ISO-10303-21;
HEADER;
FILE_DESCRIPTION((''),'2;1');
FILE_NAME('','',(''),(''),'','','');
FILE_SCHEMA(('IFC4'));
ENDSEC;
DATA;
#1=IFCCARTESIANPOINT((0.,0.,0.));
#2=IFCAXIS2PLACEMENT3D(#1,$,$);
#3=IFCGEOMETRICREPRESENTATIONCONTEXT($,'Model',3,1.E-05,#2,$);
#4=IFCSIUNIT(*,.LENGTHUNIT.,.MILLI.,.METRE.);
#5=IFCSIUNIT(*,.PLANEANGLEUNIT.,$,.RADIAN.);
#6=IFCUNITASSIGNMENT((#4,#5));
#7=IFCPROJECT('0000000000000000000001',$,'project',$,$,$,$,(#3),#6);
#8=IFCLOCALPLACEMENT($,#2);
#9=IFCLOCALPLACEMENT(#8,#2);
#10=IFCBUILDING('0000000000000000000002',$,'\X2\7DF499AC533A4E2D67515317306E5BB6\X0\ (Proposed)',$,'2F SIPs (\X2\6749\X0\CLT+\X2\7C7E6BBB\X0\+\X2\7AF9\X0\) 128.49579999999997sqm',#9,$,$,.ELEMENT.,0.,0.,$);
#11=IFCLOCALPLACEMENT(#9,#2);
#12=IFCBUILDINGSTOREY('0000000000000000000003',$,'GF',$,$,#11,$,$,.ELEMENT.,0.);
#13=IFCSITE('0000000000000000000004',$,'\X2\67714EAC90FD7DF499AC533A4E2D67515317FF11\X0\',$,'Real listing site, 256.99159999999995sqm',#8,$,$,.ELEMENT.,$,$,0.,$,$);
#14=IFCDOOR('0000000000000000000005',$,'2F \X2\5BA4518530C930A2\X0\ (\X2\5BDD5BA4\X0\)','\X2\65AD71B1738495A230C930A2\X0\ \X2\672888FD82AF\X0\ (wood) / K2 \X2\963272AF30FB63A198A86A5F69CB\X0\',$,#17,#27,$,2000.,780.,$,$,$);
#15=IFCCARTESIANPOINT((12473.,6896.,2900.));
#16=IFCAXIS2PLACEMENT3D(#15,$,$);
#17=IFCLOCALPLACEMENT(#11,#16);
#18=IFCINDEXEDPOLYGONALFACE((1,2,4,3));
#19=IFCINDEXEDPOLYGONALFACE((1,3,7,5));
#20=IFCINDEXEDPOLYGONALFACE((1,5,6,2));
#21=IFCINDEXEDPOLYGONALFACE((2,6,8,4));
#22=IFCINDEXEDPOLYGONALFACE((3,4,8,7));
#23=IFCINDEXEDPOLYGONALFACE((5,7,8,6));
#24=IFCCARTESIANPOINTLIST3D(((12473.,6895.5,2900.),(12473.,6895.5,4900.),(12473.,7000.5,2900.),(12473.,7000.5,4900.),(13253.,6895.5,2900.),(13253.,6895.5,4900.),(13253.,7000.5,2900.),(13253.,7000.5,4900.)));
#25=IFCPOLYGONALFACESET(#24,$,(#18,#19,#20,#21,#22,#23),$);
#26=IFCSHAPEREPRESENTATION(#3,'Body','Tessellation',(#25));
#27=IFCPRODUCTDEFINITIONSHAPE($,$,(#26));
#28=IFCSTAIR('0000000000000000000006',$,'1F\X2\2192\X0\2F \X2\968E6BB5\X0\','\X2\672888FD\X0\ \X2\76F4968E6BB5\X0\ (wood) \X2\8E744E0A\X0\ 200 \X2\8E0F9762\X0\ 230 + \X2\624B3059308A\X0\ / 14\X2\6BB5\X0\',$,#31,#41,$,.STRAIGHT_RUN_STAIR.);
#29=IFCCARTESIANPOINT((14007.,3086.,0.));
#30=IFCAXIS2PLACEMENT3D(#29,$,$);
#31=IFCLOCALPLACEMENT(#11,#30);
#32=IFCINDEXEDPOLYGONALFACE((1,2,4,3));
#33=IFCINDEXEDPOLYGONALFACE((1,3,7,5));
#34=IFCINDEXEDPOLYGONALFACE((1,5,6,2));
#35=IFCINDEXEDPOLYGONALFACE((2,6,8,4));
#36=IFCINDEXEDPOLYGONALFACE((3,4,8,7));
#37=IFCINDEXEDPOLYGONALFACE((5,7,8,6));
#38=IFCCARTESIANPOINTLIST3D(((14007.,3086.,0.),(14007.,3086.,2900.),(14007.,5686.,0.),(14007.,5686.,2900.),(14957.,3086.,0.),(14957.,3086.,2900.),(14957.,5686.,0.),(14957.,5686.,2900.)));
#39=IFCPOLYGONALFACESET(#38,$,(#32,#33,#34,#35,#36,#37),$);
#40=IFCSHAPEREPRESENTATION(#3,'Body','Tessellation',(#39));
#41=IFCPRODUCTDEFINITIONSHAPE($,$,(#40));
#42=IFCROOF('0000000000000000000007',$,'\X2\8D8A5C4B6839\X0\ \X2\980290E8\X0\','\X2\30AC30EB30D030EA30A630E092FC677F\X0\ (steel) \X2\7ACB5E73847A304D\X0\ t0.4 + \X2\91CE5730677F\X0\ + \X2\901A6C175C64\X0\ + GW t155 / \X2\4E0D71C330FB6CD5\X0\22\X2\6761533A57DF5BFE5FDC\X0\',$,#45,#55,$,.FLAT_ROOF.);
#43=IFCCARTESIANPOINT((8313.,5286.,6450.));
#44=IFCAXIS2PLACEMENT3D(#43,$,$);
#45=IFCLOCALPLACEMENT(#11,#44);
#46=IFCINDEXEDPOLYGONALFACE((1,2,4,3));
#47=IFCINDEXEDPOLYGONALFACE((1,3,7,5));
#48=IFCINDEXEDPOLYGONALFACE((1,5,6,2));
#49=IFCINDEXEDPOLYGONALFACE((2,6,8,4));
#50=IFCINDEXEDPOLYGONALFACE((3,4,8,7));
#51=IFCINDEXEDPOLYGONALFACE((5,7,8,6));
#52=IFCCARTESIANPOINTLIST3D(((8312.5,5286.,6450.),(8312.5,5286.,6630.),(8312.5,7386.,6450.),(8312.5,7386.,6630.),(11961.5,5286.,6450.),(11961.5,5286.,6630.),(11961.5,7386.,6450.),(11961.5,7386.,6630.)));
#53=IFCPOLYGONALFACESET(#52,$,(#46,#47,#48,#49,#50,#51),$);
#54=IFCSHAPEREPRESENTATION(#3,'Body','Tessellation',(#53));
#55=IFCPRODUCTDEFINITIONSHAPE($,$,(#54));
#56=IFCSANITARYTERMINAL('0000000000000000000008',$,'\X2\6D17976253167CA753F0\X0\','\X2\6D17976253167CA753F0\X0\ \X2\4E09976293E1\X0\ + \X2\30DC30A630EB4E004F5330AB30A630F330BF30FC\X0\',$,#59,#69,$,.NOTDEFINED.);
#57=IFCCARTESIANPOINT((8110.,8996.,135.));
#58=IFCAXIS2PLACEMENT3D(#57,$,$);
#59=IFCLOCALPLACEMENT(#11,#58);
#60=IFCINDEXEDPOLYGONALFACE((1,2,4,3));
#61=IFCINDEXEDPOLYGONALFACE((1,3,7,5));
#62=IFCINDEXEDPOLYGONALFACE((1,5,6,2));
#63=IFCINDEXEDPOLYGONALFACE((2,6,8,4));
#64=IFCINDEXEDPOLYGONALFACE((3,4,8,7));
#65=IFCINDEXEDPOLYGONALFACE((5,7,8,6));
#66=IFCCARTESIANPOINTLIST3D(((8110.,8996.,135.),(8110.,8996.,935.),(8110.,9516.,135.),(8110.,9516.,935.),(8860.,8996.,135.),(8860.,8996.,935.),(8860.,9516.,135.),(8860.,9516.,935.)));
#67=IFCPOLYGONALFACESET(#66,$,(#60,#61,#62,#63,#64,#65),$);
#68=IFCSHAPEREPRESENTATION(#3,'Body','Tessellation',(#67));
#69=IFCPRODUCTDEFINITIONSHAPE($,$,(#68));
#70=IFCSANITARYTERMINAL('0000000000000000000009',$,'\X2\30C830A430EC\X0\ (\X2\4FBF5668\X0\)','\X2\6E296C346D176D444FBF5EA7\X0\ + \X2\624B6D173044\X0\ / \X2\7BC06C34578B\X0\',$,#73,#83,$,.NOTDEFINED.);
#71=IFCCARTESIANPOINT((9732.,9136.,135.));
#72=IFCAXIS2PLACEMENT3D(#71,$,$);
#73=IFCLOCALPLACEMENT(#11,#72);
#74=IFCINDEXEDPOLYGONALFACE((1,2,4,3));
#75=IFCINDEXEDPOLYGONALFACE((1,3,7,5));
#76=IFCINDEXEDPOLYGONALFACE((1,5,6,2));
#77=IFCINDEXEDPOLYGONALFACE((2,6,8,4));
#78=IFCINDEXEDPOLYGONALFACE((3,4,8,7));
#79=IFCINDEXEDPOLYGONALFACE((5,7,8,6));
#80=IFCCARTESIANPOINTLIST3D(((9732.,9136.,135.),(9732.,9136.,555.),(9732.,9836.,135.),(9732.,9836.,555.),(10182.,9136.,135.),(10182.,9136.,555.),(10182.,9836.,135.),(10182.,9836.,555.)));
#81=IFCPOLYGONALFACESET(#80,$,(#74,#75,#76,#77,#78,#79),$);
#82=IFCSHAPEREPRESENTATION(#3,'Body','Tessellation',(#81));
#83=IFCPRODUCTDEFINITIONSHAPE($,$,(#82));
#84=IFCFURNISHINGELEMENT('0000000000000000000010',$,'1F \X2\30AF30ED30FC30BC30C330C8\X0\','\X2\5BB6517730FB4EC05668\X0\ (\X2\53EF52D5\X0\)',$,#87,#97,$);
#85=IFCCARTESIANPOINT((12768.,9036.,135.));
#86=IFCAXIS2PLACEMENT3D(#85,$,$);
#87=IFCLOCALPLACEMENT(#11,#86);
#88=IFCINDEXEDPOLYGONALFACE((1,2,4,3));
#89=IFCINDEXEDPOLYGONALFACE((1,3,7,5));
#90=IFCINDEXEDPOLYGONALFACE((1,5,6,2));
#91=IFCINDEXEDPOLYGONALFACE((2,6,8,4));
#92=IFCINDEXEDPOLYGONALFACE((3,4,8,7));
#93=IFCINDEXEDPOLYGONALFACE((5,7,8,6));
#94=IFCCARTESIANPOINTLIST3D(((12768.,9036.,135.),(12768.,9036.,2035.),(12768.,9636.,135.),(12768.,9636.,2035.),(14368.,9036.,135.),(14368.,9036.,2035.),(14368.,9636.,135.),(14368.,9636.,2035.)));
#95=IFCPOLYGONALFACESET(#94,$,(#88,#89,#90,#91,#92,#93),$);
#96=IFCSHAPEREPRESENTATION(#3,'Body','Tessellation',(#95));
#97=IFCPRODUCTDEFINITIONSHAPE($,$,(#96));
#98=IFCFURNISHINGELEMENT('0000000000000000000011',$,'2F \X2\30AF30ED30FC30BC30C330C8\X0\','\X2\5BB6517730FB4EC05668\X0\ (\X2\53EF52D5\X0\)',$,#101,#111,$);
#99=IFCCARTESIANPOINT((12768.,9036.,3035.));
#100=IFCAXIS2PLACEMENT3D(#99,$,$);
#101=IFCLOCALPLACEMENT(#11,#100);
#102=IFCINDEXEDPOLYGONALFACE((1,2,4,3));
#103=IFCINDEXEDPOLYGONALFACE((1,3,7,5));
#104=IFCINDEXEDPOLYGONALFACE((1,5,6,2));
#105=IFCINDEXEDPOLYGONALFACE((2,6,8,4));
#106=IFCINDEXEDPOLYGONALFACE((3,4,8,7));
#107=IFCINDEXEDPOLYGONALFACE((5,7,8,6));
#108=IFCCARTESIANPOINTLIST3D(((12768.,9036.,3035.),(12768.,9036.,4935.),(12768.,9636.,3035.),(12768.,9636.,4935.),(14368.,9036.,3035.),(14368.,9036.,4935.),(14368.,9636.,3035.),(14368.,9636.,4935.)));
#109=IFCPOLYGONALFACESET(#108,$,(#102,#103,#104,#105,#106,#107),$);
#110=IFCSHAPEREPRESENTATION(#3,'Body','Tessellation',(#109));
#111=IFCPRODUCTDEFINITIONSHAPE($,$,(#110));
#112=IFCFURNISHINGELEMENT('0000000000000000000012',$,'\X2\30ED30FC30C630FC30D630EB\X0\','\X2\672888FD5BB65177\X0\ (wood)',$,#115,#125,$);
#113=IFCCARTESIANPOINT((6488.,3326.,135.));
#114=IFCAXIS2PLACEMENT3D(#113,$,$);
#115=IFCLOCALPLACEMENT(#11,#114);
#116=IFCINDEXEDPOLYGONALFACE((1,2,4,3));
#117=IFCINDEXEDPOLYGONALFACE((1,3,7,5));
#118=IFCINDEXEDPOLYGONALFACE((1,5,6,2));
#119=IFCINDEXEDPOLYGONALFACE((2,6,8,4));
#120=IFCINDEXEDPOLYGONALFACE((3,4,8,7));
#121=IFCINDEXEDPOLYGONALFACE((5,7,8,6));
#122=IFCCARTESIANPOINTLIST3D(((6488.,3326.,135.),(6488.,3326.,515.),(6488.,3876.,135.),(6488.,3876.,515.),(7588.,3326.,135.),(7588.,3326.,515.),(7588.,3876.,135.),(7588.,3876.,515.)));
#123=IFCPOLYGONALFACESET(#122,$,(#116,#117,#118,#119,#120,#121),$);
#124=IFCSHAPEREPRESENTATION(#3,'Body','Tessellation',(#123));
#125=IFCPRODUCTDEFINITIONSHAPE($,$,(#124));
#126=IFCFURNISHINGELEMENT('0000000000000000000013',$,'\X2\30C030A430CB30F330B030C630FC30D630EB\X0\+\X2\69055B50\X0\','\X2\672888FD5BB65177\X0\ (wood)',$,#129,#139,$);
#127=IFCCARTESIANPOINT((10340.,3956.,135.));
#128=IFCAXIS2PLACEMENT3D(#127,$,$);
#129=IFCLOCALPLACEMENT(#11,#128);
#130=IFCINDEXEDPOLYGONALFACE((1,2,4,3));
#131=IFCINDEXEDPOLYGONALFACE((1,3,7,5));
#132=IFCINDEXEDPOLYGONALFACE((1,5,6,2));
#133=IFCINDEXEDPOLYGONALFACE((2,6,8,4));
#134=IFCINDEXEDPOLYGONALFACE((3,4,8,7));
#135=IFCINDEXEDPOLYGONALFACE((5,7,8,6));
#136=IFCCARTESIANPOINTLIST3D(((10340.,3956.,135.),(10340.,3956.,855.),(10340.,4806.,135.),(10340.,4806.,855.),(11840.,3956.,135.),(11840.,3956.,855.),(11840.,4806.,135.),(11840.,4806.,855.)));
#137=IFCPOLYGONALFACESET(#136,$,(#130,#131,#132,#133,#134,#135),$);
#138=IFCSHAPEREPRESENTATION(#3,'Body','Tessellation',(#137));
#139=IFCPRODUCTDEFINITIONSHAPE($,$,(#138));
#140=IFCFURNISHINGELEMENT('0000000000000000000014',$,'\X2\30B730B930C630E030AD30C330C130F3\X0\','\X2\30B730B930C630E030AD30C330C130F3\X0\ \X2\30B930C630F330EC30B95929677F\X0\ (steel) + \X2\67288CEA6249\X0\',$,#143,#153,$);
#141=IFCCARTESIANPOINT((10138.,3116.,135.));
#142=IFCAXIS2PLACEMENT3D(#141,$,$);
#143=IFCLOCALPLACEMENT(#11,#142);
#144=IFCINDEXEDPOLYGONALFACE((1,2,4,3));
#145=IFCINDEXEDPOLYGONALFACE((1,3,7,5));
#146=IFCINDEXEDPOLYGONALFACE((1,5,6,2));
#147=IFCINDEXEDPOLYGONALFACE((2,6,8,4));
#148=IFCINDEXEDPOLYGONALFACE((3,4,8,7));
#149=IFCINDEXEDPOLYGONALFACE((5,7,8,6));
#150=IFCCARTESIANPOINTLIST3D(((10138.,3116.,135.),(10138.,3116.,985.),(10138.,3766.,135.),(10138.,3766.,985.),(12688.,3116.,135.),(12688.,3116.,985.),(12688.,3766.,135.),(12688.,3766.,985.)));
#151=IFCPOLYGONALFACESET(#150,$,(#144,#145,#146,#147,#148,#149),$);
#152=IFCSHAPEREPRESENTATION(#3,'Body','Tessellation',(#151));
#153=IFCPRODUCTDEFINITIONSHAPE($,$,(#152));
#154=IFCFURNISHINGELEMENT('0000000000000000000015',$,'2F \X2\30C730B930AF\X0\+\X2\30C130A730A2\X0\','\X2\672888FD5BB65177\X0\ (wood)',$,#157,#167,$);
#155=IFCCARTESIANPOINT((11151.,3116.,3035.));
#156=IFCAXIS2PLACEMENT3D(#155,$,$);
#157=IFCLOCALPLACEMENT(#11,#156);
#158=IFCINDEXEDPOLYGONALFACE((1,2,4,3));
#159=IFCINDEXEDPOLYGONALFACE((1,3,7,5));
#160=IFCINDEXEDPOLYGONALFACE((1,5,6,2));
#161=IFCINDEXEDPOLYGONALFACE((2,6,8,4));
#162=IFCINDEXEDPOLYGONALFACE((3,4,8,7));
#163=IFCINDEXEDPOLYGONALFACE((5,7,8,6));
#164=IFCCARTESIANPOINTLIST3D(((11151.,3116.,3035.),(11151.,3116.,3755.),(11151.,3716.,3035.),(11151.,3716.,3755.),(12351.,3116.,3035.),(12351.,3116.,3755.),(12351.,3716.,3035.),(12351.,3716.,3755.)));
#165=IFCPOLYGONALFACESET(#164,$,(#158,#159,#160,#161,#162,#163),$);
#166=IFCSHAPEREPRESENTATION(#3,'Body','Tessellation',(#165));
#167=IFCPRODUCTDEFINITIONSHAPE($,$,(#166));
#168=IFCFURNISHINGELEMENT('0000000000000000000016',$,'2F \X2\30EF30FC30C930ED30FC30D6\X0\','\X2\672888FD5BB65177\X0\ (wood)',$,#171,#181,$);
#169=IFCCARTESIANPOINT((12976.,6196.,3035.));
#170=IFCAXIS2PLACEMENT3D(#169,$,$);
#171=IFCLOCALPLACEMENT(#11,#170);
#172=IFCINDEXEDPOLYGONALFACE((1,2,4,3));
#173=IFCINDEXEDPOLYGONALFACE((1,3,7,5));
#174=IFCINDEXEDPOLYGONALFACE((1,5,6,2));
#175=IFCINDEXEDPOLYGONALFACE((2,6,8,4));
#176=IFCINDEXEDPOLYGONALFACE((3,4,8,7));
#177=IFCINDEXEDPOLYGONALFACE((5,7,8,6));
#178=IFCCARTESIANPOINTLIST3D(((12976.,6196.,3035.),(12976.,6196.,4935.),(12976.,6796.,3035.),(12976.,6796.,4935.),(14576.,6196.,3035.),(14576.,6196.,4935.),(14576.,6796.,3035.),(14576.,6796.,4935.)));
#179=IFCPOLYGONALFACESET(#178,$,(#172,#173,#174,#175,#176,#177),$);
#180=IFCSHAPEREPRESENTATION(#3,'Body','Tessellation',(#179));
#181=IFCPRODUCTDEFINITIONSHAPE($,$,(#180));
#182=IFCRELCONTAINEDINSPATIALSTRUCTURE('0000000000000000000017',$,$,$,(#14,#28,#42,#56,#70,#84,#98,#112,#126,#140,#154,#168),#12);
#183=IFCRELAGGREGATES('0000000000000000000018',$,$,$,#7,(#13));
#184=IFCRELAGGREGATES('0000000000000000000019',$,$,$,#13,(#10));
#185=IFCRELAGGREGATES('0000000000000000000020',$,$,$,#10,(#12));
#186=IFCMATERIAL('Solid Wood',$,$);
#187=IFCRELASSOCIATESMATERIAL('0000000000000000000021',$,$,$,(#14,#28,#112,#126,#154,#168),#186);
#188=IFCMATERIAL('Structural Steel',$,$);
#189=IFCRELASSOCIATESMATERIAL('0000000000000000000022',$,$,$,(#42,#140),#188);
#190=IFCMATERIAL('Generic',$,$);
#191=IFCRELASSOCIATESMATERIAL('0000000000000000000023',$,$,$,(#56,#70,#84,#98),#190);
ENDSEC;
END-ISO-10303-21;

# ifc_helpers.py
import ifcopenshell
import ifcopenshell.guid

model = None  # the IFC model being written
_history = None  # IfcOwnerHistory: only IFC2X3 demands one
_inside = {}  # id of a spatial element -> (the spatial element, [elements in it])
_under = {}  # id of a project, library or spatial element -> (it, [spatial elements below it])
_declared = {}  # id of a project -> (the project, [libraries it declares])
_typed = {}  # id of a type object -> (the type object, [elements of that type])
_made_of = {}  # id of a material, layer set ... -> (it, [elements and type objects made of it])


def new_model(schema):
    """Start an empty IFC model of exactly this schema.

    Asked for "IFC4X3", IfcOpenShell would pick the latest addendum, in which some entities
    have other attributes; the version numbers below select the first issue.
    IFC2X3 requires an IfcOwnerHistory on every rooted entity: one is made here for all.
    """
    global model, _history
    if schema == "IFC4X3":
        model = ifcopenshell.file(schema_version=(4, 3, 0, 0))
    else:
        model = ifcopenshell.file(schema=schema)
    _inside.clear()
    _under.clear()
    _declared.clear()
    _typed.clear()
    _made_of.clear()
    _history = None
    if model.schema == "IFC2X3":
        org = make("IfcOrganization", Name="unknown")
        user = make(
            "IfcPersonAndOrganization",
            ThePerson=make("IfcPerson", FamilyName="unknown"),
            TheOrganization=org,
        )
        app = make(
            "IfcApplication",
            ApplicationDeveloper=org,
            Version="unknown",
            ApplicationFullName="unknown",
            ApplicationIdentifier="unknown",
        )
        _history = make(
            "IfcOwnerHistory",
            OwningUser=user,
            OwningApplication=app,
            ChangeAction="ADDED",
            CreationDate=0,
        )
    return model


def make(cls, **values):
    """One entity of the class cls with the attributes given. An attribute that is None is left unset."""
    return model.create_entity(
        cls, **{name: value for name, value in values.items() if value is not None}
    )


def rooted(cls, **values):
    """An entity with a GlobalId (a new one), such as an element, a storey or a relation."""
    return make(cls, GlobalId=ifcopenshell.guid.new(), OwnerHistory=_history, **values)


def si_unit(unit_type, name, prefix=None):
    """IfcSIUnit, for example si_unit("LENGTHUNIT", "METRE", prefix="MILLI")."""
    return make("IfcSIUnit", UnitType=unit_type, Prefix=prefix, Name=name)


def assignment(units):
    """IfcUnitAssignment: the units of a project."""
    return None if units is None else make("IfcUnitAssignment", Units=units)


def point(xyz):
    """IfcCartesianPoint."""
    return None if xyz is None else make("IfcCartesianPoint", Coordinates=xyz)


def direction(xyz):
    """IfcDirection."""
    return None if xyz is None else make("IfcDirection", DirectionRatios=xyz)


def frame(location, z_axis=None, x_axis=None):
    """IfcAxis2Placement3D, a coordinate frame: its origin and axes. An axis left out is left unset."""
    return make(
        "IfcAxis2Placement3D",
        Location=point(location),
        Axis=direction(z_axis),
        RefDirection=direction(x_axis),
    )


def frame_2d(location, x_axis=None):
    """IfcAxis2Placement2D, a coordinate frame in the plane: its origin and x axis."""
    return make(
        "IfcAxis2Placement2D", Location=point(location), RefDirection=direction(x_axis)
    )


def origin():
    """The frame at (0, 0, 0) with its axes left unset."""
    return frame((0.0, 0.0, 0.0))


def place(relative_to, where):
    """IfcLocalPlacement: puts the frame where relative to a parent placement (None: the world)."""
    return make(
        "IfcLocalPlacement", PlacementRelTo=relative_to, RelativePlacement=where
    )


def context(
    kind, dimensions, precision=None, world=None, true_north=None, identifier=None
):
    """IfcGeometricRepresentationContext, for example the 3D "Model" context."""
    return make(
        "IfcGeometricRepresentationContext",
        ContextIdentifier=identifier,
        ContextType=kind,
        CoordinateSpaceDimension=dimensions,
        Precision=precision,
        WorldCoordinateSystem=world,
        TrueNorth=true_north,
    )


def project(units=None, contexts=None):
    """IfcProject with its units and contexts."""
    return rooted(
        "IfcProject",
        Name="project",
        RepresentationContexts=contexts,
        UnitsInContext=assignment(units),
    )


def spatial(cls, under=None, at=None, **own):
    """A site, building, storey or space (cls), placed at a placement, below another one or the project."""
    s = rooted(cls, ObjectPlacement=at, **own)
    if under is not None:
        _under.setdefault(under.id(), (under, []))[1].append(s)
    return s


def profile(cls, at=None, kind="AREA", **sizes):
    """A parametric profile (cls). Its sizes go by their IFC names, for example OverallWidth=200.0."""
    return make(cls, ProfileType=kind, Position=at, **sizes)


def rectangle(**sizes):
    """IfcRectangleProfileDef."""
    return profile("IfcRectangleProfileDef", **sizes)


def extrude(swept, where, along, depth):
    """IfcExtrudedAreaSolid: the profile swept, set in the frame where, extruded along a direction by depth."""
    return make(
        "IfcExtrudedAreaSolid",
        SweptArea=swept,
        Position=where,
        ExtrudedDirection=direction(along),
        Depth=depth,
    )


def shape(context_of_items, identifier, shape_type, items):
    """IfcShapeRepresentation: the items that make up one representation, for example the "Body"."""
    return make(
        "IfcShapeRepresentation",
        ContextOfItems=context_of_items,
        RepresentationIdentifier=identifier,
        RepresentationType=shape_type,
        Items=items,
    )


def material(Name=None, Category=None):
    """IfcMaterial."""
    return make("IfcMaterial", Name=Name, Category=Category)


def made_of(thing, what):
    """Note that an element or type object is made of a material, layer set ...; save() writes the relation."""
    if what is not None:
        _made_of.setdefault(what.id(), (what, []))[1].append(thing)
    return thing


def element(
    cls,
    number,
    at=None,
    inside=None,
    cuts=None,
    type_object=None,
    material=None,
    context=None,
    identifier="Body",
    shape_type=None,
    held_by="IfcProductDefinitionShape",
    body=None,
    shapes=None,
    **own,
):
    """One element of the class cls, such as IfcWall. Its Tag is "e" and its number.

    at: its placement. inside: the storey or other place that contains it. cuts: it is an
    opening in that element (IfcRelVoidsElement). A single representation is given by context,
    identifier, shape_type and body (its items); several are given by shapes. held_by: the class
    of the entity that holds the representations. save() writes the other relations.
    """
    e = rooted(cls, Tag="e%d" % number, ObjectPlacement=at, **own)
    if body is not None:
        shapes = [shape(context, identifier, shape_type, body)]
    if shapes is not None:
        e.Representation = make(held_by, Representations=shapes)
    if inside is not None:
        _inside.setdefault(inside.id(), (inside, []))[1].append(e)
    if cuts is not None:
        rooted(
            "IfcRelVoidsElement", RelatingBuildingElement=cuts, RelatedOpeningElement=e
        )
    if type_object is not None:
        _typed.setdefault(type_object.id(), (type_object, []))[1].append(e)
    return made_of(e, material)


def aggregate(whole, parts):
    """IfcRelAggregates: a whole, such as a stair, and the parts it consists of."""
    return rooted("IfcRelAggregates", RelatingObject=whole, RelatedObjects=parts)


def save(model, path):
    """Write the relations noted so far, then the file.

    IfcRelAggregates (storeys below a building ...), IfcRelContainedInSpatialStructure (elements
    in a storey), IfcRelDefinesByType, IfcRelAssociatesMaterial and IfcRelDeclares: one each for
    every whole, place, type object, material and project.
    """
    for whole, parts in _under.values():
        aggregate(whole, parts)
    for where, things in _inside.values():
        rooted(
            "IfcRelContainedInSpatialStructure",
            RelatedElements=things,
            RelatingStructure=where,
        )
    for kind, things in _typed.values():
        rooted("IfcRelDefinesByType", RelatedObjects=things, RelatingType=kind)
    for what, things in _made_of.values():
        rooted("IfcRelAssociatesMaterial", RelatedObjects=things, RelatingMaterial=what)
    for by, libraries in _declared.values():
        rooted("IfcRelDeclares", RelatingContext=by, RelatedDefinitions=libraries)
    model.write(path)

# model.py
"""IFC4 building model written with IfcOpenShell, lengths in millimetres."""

from ifc_helpers import new_model, si_unit, frame, frame_2d, origin, place, context, project, spatial, rectangle, extrude, material, element, save


model = new_model("IFC4")

# Units and contexts
model_context = context("Model", 3, precision=1e-05, world=origin())
ifc_project = project(units=[si_unit("LENGTHUNIT", "METRE", prefix="MILLI"), si_unit("PLANEANGLEUNIT", "RADIAN")], contexts=[model_context])

# Site, building, storey
site_placement = place(None, origin())
site = spatial("IfcSite", under=ifc_project, at=site_placement, Name="東京都練馬区中村北１", ObjectType="Real listing site, 256.99159999999995sqm", CompositionType="ELEMENT", RefElevation=0.0)
building_placement = place(site_placement, origin())
building = spatial("IfcBuilding", under=site, at=building_placement, Name="練馬区中村北の家 (Proposed)", ObjectType="2F SIPs (杉CLT+籾殻+竹) 128.49579999999997sqm", CompositionType="ELEMENT", ElevationOfRefHeight=0.0, ElevationOfTerrain=0.0)
storey_placement = place(building_placement, origin())
storey = spatial("IfcBuildingStorey", under=building, at=storey_placement, Name="GF", CompositionType="ELEMENT", Elevation=0.0)

# Shared definitions
ifc_material_1 = material(Name="Solid Wood")

# Door
door_1_placement = place(storey_placement, frame((12473.0, 6896.0, 2900.0)))
element("IfcDoor", 1, at=door_1_placement, inside=storey, material=ifc_material_1, Name="2F 室内ドア (寝室)", Description="断熱玄関ドア 木製芯 (wood) / K2 防犯・採風機構", OverallHeight=2000.0, OverallWidth=780.0, context=model_context, shape_type="SweptSolid", body=[
    extrude(rectangle(XDim=780.0, YDim=105.0, at=frame_2d((390.0, 52.0))), frame((12473.0, 6896.0, 2900.0)), (0.0, 0.0, 1.0), 2000.0),
])

# Stair
stair_placement = place(storey_placement, frame((14007.0, 3086.0, 0.0)))
element("IfcStair", 2, at=stair_placement, inside=storey, material=ifc_material_1, Name="1F→2F 階段", Description="木製 直階段 (wood) 蹴上 200 踏面 230 + 手すり / 14段", PredefinedType="STRAIGHT_RUN_STAIR", context=model_context, shape_type="SweptSolid", body=[
    extrude(rectangle(XDim=950.0, YDim=2600.0, at=frame_2d((475.0, 1300.0))), frame((14007.0, 3086.0, 0.0)), (0.0, 0.0, 1.0), 2900.0),
])

# Roof
ifc_material_2 = material(Name="Structural Steel")
roof_placement = place(storey_placement, frame((8313.0, 5286.0, 6450.0)))
element("IfcRoof", 3, at=roof_placement, inside=storey, material=ifc_material_2, Name="越屋根 頂部", Description="ガルバリウム鋼板 (steel) 立平葺き t0.4 + 野地板 + 通気層 + GW t155 / 不燃・法22条区域対応", PredefinedType="FLAT_ROOF", context=model_context, shape_type="SweptSolid", body=[
    extrude(rectangle(XDim=3649.0, YDim=2100.0, at=frame_2d((1824.0, 1050.0))), frame((8313.0, 5286.0, 6450.0)), (0.0, 0.0, 1.0), 180.0),
])

# Sanitary terminals
ifc_material_3 = material(Name="Generic")
sanitary_terminal_1_placement = place(storey_placement, frame((8110.0, 8996.0, 135.0)))
element("IfcSanitaryTerminal", 4, at=sanitary_terminal_1_placement, inside=storey, material=ifc_material_3, Name="洗面化粧台", Description="洗面化粧台 三面鏡 + ボウル一体カウンター", PredefinedType="NOTDEFINED", context=model_context, shape_type="SweptSolid", body=[
    extrude(rectangle(XDim=750.0, YDim=520.0, at=frame_2d((375.0, 260.0))), frame((8110.0, 8996.0, 135.0)), (0.0, 0.0, 1.0), 800.0),
])
sanitary_terminal_2_placement = place(storey_placement, frame((9732.0, 9136.0, 135.0)))
element("IfcSanitaryTerminal", 5, at=sanitary_terminal_2_placement, inside=storey, material=ifc_material_3, Name="トイレ (便器)", Description="温水洗浄便座 + 手洗い / 節水型", PredefinedType="NOTDEFINED", context=model_context, shape_type="SweptSolid", body=[
    extrude(rectangle(XDim=450.0, YDim=700.0, at=frame_2d((225.0, 350.0))), frame((9732.0, 9136.0, 135.0)), (0.0, 0.0, 1.0), 420.0),
])

# Furnishing elements
furnishing_1_placement = place(storey_placement, frame((12768.0, 9036.0, 135.0)))
element("IfcFurnishingElement", 6, at=furnishing_1_placement, inside=storey, material=ifc_material_3, Name="1F クローゼット", Description="家具・什器 (可動)", context=model_context, shape_type="SweptSolid", body=[
    extrude(rectangle(XDim=1600.0, YDim=600.0, at=frame_2d((800.0, 300.0))), frame((12768.0, 9036.0, 135.0)), (0.0, 0.0, 1.0), 1900.0),
])
furnishing_2_placement = place(storey_placement, frame((12768.0, 9036.0, 3035.0)))
element("IfcFurnishingElement", 7, at=furnishing_2_placement, inside=storey, material=ifc_material_3, Name="2F クローゼット", Description="家具・什器 (可動)", context=model_context, shape_type="SweptSolid", body=[
    extrude(rectangle(XDim=1600.0, YDim=600.0, at=frame_2d((800.0, 300.0))), frame((12768.0, 9036.0, 3035.0)), (0.0, 0.0, 1.0), 1900.0),
])
furnishing_3_placement = place(storey_placement, frame((6488.0, 3326.0, 135.0)))
element("IfcFurnishingElement", 8, at=furnishing_3_placement, inside=storey, material=ifc_material_1, Name="ローテーブル", Description="木製家具 (wood)", context=model_context, shape_type="SweptSolid", body=[
    extrude(rectangle(XDim=1100.0, YDim=550.0, at=frame_2d((550.0, 275.0))), frame((6488.0, 3326.0, 135.0)), (0.0, 0.0, 1.0), 380.0),
])
furnishing_4_placement = place(storey_placement, frame((10340.0, 3956.0, 135.0)))
element("IfcFurnishingElement", 9, at=furnishing_4_placement, inside=storey, material=ifc_material_1, Name="ダイニングテーブル+椅子", Description="木製家具 (wood)", context=model_context, shape_type="SweptSolid", body=[
    extrude(rectangle(XDim=1500.0, YDim=850.0, at=frame_2d((750.0, 425.0))), frame((10340.0, 3956.0, 135.0)), (0.0, 0.0, 1.0), 720.0),
])
furnishing_5_placement = place(storey_placement, frame((10138.0, 3116.0, 135.0)))
element("IfcFurnishingElement", 10, at=furnishing_5_placement, inside=storey, material=ifc_material_2, Name="システムキッチン", Description="システムキッチン ステンレス天板 (steel) + 木質扉", context=model_context, shape_type="SweptSolid", body=[
    extrude(rectangle(XDim=2550.0, YDim=650.0, at=frame_2d((1275.0, 325.0))), frame((10138.0, 3116.0, 135.0)), (0.0, 0.0, 1.0), 850.0),
])
furnishing_6_placement = place(storey_placement, frame((11151.0, 3116.0, 3035.0)))
element("IfcFurnishingElement", 11, at=furnishing_6_placement, inside=storey, material=ifc_material_1, Name="2F デスク+チェア", Description="木製家具 (wood)", context=model_context, shape_type="SweptSolid", body=[
    extrude(rectangle(XDim=1200.0, YDim=600.0, at=frame_2d((600.0, 300.0))), frame((11151.0, 3116.0, 3035.0)), (0.0, 0.0, 1.0), 720.0),
])
furnishing_7_placement = place(storey_placement, frame((12976.0, 6196.0, 3035.0)))
element("IfcFurnishingElement", 12, at=furnishing_7_placement, inside=storey, material=ifc_material_1, Name="2F ワードローブ", Description="木製家具 (wood)", context=model_context, shape_type="SweptSolid", body=[
    extrude(rectangle(XDim=1600.0, YDim=600.0, at=frame_2d((800.0, 300.0))), frame((12976.0, 6196.0, 3035.0)), (0.0, 0.0, 1.0), 1900.0),
])

save(model, "model.ifc")
